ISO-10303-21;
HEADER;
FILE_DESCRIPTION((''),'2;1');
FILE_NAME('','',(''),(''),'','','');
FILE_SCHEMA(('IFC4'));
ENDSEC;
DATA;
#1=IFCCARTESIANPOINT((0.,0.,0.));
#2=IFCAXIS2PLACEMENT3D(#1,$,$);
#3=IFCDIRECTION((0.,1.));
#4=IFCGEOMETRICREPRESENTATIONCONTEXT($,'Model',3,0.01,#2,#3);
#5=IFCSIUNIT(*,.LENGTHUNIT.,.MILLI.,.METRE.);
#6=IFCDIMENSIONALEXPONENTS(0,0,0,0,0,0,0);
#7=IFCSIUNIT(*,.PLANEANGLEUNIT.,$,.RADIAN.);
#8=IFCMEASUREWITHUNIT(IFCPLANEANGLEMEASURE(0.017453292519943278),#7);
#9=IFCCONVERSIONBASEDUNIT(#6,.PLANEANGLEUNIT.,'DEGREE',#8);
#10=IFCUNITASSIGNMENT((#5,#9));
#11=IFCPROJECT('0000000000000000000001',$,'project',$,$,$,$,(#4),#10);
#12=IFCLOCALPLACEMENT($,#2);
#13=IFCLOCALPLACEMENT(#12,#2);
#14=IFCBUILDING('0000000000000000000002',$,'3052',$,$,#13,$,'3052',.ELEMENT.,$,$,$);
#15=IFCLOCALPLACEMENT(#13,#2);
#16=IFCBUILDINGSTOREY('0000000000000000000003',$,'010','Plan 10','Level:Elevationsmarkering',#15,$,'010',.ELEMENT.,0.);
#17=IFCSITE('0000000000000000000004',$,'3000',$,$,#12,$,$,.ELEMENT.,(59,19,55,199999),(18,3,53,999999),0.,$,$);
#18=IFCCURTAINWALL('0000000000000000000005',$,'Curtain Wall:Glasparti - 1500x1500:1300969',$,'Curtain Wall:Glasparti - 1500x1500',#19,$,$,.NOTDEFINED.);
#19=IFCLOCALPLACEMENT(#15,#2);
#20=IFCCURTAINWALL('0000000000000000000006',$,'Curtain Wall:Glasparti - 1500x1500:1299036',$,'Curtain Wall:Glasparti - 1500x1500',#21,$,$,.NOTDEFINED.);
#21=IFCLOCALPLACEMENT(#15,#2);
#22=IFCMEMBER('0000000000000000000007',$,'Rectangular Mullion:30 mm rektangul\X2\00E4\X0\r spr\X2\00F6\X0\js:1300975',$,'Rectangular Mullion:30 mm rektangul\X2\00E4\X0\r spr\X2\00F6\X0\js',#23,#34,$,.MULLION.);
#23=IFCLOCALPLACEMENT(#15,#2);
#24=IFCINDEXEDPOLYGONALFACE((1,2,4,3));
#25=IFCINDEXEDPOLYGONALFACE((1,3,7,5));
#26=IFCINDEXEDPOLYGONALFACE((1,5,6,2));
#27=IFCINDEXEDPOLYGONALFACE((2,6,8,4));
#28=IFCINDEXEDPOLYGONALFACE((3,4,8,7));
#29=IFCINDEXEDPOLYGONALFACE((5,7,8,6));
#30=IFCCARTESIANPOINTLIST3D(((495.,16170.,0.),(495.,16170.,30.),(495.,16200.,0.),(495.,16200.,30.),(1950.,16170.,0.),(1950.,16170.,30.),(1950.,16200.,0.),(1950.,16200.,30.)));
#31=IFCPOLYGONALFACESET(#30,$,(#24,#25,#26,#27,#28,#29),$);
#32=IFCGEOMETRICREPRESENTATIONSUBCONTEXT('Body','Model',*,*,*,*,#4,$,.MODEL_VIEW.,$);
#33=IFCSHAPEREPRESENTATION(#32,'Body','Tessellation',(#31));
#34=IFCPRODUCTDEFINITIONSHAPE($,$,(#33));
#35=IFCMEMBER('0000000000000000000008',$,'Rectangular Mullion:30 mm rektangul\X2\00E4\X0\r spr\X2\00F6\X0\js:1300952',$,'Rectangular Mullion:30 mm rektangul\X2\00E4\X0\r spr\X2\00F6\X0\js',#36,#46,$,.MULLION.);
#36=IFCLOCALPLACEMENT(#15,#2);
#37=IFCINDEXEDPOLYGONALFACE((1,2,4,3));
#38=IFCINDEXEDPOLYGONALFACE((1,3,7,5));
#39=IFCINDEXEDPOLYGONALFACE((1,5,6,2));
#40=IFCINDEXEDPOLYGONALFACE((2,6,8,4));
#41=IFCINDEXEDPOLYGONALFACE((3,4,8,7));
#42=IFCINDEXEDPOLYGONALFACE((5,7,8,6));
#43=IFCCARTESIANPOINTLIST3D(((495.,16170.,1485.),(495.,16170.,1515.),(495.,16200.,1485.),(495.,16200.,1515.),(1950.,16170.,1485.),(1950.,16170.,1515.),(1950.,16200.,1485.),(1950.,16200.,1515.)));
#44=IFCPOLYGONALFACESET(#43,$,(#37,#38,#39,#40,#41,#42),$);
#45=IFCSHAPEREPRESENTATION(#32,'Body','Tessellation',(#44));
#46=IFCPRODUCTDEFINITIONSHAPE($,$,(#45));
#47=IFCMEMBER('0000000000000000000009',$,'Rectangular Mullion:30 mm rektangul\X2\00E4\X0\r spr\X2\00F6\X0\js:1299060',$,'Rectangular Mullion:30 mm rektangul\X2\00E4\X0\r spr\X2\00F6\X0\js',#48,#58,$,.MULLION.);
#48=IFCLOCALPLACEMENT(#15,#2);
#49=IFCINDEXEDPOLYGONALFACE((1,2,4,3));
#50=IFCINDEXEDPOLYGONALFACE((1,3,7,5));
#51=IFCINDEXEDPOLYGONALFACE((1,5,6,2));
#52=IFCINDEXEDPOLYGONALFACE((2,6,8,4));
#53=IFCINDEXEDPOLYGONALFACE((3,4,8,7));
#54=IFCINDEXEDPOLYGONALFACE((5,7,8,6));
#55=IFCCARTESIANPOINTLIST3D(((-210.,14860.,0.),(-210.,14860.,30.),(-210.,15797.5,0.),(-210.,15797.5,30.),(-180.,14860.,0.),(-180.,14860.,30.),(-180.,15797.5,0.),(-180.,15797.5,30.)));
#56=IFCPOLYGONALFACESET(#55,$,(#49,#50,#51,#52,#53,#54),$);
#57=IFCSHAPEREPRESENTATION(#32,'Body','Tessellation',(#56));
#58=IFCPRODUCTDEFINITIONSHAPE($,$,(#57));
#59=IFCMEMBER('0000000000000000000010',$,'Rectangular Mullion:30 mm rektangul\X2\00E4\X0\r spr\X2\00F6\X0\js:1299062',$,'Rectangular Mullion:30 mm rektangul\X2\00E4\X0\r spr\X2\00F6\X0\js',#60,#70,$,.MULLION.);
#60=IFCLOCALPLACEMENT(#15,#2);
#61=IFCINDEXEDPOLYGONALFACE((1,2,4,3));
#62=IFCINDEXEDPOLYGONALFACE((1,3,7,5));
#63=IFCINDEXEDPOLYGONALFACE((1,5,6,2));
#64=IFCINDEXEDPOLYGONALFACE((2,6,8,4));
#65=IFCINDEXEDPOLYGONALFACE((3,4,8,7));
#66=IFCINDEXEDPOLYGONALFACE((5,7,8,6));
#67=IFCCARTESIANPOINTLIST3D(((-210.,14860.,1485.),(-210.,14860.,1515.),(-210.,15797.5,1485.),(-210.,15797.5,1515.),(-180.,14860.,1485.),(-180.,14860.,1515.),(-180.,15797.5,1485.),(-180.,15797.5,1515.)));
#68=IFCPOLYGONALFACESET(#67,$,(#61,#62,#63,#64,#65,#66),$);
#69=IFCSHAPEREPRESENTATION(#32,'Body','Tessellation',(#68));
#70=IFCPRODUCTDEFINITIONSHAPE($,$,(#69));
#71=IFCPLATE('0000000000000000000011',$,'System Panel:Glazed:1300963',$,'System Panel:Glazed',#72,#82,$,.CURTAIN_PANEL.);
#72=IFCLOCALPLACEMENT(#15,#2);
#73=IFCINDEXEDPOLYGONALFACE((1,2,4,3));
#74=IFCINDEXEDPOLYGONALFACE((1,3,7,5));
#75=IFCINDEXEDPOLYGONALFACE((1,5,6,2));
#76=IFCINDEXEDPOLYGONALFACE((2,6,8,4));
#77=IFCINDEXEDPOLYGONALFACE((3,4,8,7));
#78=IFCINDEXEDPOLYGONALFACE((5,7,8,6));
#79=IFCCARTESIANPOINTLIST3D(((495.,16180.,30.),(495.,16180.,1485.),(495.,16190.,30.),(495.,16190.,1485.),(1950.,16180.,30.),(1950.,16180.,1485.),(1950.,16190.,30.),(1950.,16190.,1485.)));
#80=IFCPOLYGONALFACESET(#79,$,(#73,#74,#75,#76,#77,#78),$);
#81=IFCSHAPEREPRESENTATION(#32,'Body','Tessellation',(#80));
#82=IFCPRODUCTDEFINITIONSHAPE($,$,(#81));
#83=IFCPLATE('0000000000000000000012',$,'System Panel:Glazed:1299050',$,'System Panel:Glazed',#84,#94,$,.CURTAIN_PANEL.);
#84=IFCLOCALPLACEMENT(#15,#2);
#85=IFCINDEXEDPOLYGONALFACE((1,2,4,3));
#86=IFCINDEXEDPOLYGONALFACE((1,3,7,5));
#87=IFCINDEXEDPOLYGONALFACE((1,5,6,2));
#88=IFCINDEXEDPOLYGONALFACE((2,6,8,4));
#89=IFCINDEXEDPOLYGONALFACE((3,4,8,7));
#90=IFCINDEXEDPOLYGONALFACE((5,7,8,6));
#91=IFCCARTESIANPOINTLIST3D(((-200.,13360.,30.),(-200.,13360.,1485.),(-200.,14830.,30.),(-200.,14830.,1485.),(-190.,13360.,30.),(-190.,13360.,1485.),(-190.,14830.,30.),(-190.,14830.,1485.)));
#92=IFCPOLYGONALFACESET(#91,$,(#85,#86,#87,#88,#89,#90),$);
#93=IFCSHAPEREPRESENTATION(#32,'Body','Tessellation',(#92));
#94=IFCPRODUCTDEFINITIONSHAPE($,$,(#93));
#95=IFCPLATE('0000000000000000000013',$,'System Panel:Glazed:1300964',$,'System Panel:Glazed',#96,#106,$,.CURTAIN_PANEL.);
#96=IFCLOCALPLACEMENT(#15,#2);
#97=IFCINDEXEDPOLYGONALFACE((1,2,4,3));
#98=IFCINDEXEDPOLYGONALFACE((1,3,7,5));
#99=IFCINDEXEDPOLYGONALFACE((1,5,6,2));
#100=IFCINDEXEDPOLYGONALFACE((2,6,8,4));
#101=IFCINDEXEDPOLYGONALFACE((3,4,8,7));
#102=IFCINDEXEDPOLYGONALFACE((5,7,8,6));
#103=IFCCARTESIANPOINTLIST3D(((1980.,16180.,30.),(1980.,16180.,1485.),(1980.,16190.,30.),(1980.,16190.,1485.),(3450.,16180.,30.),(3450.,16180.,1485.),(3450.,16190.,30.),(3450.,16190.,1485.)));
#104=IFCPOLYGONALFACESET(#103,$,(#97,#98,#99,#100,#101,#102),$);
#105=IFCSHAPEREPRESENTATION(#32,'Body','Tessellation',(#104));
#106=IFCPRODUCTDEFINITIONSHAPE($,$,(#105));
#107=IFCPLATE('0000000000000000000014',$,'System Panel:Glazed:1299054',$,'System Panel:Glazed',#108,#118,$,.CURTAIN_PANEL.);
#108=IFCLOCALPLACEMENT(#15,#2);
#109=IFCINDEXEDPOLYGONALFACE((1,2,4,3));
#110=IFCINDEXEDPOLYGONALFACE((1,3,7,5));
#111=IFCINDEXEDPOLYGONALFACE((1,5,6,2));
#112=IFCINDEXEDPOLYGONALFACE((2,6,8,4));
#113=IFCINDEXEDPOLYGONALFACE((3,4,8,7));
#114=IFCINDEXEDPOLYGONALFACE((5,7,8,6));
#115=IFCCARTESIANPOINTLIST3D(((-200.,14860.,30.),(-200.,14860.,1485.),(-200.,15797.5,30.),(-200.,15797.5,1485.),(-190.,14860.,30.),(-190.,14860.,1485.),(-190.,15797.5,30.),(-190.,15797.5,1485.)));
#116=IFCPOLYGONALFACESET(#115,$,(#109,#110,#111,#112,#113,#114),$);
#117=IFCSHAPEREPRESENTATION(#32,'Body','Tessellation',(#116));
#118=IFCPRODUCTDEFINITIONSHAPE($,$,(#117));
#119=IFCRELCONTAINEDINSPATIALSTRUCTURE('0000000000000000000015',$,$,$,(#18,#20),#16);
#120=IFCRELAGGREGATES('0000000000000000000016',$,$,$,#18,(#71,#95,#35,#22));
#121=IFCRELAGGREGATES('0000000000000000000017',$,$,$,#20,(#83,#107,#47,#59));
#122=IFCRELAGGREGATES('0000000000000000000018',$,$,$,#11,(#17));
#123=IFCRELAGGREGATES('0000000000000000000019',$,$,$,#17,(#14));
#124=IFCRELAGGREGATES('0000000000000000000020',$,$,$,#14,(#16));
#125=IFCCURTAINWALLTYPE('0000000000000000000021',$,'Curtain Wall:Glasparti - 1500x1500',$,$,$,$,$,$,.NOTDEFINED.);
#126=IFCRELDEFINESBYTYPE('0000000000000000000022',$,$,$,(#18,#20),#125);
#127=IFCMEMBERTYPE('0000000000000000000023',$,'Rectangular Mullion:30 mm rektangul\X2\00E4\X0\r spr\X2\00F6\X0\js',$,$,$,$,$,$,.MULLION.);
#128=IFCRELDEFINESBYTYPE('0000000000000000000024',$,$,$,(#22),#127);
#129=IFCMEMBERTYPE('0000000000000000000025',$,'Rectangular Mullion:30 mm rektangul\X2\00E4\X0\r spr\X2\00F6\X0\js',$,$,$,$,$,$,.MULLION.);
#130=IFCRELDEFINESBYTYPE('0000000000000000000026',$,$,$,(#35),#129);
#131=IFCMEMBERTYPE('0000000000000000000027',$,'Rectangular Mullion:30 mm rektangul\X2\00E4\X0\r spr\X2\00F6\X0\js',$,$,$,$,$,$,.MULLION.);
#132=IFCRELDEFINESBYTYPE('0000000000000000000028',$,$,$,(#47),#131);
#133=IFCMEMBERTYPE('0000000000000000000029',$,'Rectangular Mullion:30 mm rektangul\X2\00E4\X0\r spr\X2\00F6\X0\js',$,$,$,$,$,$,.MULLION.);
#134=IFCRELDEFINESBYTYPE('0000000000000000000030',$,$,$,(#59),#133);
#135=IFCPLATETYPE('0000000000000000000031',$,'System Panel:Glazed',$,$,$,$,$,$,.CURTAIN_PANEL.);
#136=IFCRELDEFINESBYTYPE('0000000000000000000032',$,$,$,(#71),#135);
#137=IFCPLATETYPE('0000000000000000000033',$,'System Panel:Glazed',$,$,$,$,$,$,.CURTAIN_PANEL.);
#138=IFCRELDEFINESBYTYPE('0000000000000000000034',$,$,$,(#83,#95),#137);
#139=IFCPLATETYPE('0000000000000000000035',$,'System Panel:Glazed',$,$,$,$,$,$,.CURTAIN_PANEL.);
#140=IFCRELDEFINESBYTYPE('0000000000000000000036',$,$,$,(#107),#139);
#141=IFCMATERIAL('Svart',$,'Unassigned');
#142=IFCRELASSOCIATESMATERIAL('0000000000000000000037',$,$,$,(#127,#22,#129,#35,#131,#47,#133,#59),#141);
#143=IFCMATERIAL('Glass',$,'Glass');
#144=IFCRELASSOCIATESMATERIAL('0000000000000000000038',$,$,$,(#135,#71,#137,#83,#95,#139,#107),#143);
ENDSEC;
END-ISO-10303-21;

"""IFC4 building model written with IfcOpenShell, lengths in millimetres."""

from ifc_helpers import new_model, entity, si_unit, converted_unit, direction, frame, origin, place, context, subcontext, project, spatial, indexed_curve, outline, extrude, source, transform, mapped, material, type_object, type_shapes, element, aggregate, save


model = new_model("IFC4")

# Units and contexts
model_context = context("Model", 3, precision=0.01, world=origin(), true_north=direction((0.0, 1.0)))
body_context = subcontext(model_context, "Body", "Model", "MODEL_VIEW")
ifc_project = project(units=[si_unit("LENGTHUNIT", "METRE", prefix="MILLI"), converted_unit("PLANEANGLEUNIT", "DEGREE", entity("IfcPlaneAngleMeasure", 0.017453292519943278), si_unit("PLANEANGLEUNIT", "RADIAN"), dimensions=[0, 0, 0, 0, 0, 0, 0])], contexts=[model_context])

# Site, building, storey
site_placement = place(None, origin())
site = spatial("IfcSite", under=ifc_project, at=site_placement, Name="3000", CompositionType="ELEMENT", RefLatitude=(59, 19, 55, 199999), RefLongitude=(18, 3, 53, 999999), RefElevation=0.0)
building_placement = place(site_placement, origin())
building = spatial("IfcBuilding", under=site, at=building_placement, Name="3052", LongName="3052", CompositionType="ELEMENT")
storey_placement = place(building_placement, origin())
storey = spatial("IfcBuildingStorey", under=building, at=storey_placement, Name="010", Description="Plan 10", ObjectType="Level:Elevationsmarkering", LongName="010", CompositionType="ELEMENT", Elevation=0.0)

# Curtain wall
curtain_wall_type = type_object("IfcCurtainWallType", Name="Curtain Wall:Glasparti - 1500x1500", PredefinedType="NOTDEFINED")
curtain_wall_1_placement = place(storey_placement, origin())
curtain_wall_1 = element("IfcCurtainWall", 1, at=curtain_wall_1_placement, inside=storey, type_object=curtain_wall_type, Name="Curtain Wall:Glasparti - 1500x1500:1300969", ObjectType="Curtain Wall:Glasparti - 1500x1500", PredefinedType="NOTDEFINED")
ifc_material_1 = material(Name="Svart", Category="Unassigned")

# Curtain wall
curtain_wall_2_placement = place(storey_placement, origin())
curtain_wall_2 = element("IfcCurtainWall", 2, at=curtain_wall_2_placement, inside=storey, type_object=curtain_wall_type, Name="Curtain Wall:Glasparti - 1500x1500:1299036", ObjectType="Curtain Wall:Glasparti - 1500x1500", PredefinedType="NOTDEFINED")

# Members
member_type_1 = type_object("IfcMemberType", Name="Rectangular Mullion:30 mm rektangulär spröjs", PredefinedType="MULLION", material=ifc_material_1)
shared_shape_1 = source(origin(), body_context, "Body", "SweptSolid", [
    extrude(outline(indexed_curve([(-15.0, -15.0), (15.0, -15.0), (15.0, 15.0), (-15.0, 15.0), (-15.0, -15.0)], self_intersect=False)), frame((-15.0, 0.0, -1455.0), z_axis=(0.0, 0.0, 1.0), x_axis=(-1.0, 0.0, 0.0)), (0.0, 0.0, 1.0), 1455.0),
])
type_shapes(member_type_1, [shared_shape_1])
member_1_placement = place(curtain_wall_1_placement, frame((495.0, 16185.0, 0.0), z_axis=(-1.0, 0.0, 0.0), x_axis=(0.0, 0.0, -1.0)))
member_1 = element("IfcMember", 3, at=member_1_placement, type_object=member_type_1, material=ifc_material_1, Name="Rectangular Mullion:30 mm rektangulär spröjs:1300975", ObjectType="Rectangular Mullion:30 mm rektangulär spröjs", PredefinedType="MULLION", context=body_context, shape_type="MappedRepresentation", body=[
    mapped(shared_shape_1, transform((0.0, 0.0, 0.0), scale=1.0)),
])
member_type_2 = type_object("IfcMemberType", Name="Rectangular Mullion:30 mm rektangulär spröjs", PredefinedType="MULLION", material=ifc_material_1)
shared_shape_2 = source(origin(), body_context, "Body", "SweptSolid", [
    extrude(outline(indexed_curve([(-15.0, -15.0), (15.0, -15.0), (15.0, 15.0), (-15.0, 15.0), (-15.0, -15.0)], self_intersect=False)), frame((0.0, 0.0, -1455.0), z_axis=(0.0, 0.0, 1.0), x_axis=(-1.0, 0.0, 0.0)), (0.0, 0.0, 1.0), 1455.0),
])
type_shapes(member_type_2, [shared_shape_2])
member_2_placement = place(curtain_wall_1_placement, frame((1950.0, 16185.0, 1500.0), z_axis=(1.0, 0.0, 0.0), x_axis=(0.0, 0.0, 1.0)))
member_2 = element("IfcMember", 4, at=member_2_placement, type_object=member_type_2, material=ifc_material_1, Name="Rectangular Mullion:30 mm rektangulär spröjs:1300952", ObjectType="Rectangular Mullion:30 mm rektangulär spröjs", PredefinedType="MULLION", context=body_context, shape_type="MappedRepresentation", body=[
    mapped(shared_shape_2, transform((0.0, 0.0, 0.0), scale=1.0)),
])
member_type_3 = type_object("IfcMemberType", Name="Rectangular Mullion:30 mm rektangulär spröjs", PredefinedType="MULLION", material=ifc_material_1)
shared_shape_3 = source(origin(), body_context, "Body", "SweptSolid", [
    extrude(outline(indexed_curve([(-15.0, -15.0), (15.0, -15.0), (15.0, 15.0), (-15.0, 15.0), (-15.0, -15.0)], self_intersect=False)), frame((-15.0, 0.0, -937.5), z_axis=(0.0, 0.0, 1.0), x_axis=(-1.0, 0.0, 0.0)), (0.0, 0.0, 1.0), 937.5),
])
type_shapes(member_type_3, [shared_shape_3])
member_3_placement = place(curtain_wall_2_placement, frame((-195.0, 14860.0, 0.0), z_axis=(0.0, -1.0, 0.0), x_axis=(0.0, 0.0, -1.0)))
member_3 = element("IfcMember", 5, at=member_3_placement, type_object=member_type_3, material=ifc_material_1, Name="Rectangular Mullion:30 mm rektangulär spröjs:1299060", ObjectType="Rectangular Mullion:30 mm rektangulär spröjs", PredefinedType="MULLION", context=body_context, shape_type="MappedRepresentation", body=[
    mapped(shared_shape_3, transform((0.0, 0.0, 0.0), scale=1.0)),
])
member_type_4 = type_object("IfcMemberType", Name="Rectangular Mullion:30 mm rektangulär spröjs", PredefinedType="MULLION", material=ifc_material_1)
shared_shape_4 = source(origin(), body_context, "Body", "SweptSolid", [
    extrude(outline(indexed_curve([(-15.0, -15.0), (15.0, -15.0), (15.0, 15.0), (-15.0, 15.0), (-15.0, -15.0)], self_intersect=False)), frame((0.0, 0.0, -937.5), z_axis=(0.0, 0.0, 1.0), x_axis=(-1.0, 0.0, 0.0)), (0.0, 0.0, 1.0), 937.5),
])
type_shapes(member_type_4, [shared_shape_4])
member_4_placement = place(curtain_wall_2_placement, frame((-195.0, 15797.5, 1500.0), z_axis=(0.0, 1.0, 0.0), x_axis=(0.0, 0.0, 1.0)))
member_4 = element("IfcMember", 6, at=member_4_placement, type_object=member_type_4, material=ifc_material_1, Name="Rectangular Mullion:30 mm rektangulär spröjs:1299062", ObjectType="Rectangular Mullion:30 mm rektangulär spröjs", PredefinedType="MULLION", context=body_context, shape_type="MappedRepresentation", body=[
    mapped(shared_shape_4, transform((0.0, 0.0, 0.0), scale=1.0)),
])

# Plates
ifc_material_2 = material(Name="Glass", Category="Glass")
plate_type_1 = type_object("IfcPlateType", Name="System Panel:Glazed", PredefinedType="CURTAIN_PANEL", material=ifc_material_2)
shared_shape_5 = source(origin(), body_context, "Body", "SweptSolid", [
    extrude(outline(indexed_curve([(-5.0, -727.5), (5.0, -727.5), (5.0, 727.5), (-5.0, 727.5), (-5.0, -727.5)], self_intersect=False)), frame((0.0, 0.0, 0.0), z_axis=(0.0, 0.0, 1.0), x_axis=(0.0, 1.0, 0.0)), (0.0, 0.0, 1.0), 1455.0),
])
type_shapes(plate_type_1, [shared_shape_5])
plate_1_placement = place(curtain_wall_1_placement, frame((1222.5, 16185.0, 30.0)))
plate_1 = element("IfcPlate", 7, at=plate_1_placement, type_object=plate_type_1, material=ifc_material_2, Name="System Panel:Glazed:1300963", ObjectType="System Panel:Glazed", PredefinedType="CURTAIN_PANEL", context=body_context, shape_type="MappedRepresentation", body=[
    mapped(shared_shape_5, transform((0.0, 0.0, 0.0), scale=1.0)),
])
plate_type_2 = type_object("IfcPlateType", Name="System Panel:Glazed", PredefinedType="CURTAIN_PANEL", material=ifc_material_2)
shared_shape_6 = source(origin(), body_context, "Body", "SweptSolid", [
    extrude(outline(indexed_curve([(-5.0, -735.0), (5.0, -735.0), (5.0, 735.0), (-5.0, 735.0), (-5.0, -735.0)], self_intersect=False)), frame((0.0, 0.0, 0.0), z_axis=(0.0, 0.0, 1.0), x_axis=(0.0, 1.0, 0.0)), (0.0, 0.0, 1.0), 1455.0),
])
type_shapes(plate_type_2, [shared_shape_6])
plate_2_placement = place(curtain_wall_2_placement, frame((-195.0, 14095.0, 30.0), z_axis=(0.0, 0.0, 1.0), x_axis=(0.0, 1.0, 0.0)))
plate_2 = element("IfcPlate", 8, at=plate_2_placement, type_object=plate_type_2, material=ifc_material_2, Name="System Panel:Glazed:1299050", ObjectType="System Panel:Glazed", PredefinedType="CURTAIN_PANEL", context=body_context, shape_type="MappedRepresentation", body=[
    mapped(shared_shape_6, transform((0.0, 0.0, 0.0), scale=1.0)),
])
plate_3_placement = place(curtain_wall_1_placement, frame((2715.0, 16185.0, 30.0)))
plate_3 = element("IfcPlate", 9, at=plate_3_placement, type_object=plate_type_2, material=ifc_material_2, Name="System Panel:Glazed:1300964", ObjectType="System Panel:Glazed", PredefinedType="CURTAIN_PANEL", context=body_context, shape_type="MappedRepresentation", body=[
    mapped(shared_shape_6, transform((0.0, 0.0, 0.0), scale=1.0)),
])
aggregate(curtain_wall_1, [plate_1, plate_3, member_2, member_1])
plate_type_3 = type_object("IfcPlateType", Name="System Panel:Glazed", PredefinedType="CURTAIN_PANEL", material=ifc_material_2)
shared_shape_7 = source(origin(), body_context, "Body", "SweptSolid", [
    extrude(outline(indexed_curve([(-5.0, -468.7), (5.0, -468.7), (5.0, 468.7), (-5.0, 468.7), (-5.0, -468.7)], self_intersect=False)), frame((0.0, 0.0, 0.0), z_axis=(0.0, 0.0, 1.0), x_axis=(0.0, 1.0, 0.0)), (0.0, 0.0, 1.0), 1455.0),
])
type_shapes(plate_type_3, [shared_shape_7])
plate_4_placement = place(curtain_wall_2_placement, frame((-195.0, 15328.8, 30.0), z_axis=(0.0, 0.0, 1.0), x_axis=(0.0, 1.0, 0.0)))
plate_4 = element("IfcPlate", 10, at=plate_4_placement, type_object=plate_type_3, material=ifc_material_2, Name="System Panel:Glazed:1299054", ObjectType="System Panel:Glazed", PredefinedType="CURTAIN_PANEL", context=body_context, shape_type="MappedRepresentation", body=[
    mapped(shared_shape_7, transform((0.0, 0.0, 0.0), scale=1.0)),
])
aggregate(curtain_wall_2, [plate_2, plate_4, member_3, member_4])

save(model, "model.ifc")
